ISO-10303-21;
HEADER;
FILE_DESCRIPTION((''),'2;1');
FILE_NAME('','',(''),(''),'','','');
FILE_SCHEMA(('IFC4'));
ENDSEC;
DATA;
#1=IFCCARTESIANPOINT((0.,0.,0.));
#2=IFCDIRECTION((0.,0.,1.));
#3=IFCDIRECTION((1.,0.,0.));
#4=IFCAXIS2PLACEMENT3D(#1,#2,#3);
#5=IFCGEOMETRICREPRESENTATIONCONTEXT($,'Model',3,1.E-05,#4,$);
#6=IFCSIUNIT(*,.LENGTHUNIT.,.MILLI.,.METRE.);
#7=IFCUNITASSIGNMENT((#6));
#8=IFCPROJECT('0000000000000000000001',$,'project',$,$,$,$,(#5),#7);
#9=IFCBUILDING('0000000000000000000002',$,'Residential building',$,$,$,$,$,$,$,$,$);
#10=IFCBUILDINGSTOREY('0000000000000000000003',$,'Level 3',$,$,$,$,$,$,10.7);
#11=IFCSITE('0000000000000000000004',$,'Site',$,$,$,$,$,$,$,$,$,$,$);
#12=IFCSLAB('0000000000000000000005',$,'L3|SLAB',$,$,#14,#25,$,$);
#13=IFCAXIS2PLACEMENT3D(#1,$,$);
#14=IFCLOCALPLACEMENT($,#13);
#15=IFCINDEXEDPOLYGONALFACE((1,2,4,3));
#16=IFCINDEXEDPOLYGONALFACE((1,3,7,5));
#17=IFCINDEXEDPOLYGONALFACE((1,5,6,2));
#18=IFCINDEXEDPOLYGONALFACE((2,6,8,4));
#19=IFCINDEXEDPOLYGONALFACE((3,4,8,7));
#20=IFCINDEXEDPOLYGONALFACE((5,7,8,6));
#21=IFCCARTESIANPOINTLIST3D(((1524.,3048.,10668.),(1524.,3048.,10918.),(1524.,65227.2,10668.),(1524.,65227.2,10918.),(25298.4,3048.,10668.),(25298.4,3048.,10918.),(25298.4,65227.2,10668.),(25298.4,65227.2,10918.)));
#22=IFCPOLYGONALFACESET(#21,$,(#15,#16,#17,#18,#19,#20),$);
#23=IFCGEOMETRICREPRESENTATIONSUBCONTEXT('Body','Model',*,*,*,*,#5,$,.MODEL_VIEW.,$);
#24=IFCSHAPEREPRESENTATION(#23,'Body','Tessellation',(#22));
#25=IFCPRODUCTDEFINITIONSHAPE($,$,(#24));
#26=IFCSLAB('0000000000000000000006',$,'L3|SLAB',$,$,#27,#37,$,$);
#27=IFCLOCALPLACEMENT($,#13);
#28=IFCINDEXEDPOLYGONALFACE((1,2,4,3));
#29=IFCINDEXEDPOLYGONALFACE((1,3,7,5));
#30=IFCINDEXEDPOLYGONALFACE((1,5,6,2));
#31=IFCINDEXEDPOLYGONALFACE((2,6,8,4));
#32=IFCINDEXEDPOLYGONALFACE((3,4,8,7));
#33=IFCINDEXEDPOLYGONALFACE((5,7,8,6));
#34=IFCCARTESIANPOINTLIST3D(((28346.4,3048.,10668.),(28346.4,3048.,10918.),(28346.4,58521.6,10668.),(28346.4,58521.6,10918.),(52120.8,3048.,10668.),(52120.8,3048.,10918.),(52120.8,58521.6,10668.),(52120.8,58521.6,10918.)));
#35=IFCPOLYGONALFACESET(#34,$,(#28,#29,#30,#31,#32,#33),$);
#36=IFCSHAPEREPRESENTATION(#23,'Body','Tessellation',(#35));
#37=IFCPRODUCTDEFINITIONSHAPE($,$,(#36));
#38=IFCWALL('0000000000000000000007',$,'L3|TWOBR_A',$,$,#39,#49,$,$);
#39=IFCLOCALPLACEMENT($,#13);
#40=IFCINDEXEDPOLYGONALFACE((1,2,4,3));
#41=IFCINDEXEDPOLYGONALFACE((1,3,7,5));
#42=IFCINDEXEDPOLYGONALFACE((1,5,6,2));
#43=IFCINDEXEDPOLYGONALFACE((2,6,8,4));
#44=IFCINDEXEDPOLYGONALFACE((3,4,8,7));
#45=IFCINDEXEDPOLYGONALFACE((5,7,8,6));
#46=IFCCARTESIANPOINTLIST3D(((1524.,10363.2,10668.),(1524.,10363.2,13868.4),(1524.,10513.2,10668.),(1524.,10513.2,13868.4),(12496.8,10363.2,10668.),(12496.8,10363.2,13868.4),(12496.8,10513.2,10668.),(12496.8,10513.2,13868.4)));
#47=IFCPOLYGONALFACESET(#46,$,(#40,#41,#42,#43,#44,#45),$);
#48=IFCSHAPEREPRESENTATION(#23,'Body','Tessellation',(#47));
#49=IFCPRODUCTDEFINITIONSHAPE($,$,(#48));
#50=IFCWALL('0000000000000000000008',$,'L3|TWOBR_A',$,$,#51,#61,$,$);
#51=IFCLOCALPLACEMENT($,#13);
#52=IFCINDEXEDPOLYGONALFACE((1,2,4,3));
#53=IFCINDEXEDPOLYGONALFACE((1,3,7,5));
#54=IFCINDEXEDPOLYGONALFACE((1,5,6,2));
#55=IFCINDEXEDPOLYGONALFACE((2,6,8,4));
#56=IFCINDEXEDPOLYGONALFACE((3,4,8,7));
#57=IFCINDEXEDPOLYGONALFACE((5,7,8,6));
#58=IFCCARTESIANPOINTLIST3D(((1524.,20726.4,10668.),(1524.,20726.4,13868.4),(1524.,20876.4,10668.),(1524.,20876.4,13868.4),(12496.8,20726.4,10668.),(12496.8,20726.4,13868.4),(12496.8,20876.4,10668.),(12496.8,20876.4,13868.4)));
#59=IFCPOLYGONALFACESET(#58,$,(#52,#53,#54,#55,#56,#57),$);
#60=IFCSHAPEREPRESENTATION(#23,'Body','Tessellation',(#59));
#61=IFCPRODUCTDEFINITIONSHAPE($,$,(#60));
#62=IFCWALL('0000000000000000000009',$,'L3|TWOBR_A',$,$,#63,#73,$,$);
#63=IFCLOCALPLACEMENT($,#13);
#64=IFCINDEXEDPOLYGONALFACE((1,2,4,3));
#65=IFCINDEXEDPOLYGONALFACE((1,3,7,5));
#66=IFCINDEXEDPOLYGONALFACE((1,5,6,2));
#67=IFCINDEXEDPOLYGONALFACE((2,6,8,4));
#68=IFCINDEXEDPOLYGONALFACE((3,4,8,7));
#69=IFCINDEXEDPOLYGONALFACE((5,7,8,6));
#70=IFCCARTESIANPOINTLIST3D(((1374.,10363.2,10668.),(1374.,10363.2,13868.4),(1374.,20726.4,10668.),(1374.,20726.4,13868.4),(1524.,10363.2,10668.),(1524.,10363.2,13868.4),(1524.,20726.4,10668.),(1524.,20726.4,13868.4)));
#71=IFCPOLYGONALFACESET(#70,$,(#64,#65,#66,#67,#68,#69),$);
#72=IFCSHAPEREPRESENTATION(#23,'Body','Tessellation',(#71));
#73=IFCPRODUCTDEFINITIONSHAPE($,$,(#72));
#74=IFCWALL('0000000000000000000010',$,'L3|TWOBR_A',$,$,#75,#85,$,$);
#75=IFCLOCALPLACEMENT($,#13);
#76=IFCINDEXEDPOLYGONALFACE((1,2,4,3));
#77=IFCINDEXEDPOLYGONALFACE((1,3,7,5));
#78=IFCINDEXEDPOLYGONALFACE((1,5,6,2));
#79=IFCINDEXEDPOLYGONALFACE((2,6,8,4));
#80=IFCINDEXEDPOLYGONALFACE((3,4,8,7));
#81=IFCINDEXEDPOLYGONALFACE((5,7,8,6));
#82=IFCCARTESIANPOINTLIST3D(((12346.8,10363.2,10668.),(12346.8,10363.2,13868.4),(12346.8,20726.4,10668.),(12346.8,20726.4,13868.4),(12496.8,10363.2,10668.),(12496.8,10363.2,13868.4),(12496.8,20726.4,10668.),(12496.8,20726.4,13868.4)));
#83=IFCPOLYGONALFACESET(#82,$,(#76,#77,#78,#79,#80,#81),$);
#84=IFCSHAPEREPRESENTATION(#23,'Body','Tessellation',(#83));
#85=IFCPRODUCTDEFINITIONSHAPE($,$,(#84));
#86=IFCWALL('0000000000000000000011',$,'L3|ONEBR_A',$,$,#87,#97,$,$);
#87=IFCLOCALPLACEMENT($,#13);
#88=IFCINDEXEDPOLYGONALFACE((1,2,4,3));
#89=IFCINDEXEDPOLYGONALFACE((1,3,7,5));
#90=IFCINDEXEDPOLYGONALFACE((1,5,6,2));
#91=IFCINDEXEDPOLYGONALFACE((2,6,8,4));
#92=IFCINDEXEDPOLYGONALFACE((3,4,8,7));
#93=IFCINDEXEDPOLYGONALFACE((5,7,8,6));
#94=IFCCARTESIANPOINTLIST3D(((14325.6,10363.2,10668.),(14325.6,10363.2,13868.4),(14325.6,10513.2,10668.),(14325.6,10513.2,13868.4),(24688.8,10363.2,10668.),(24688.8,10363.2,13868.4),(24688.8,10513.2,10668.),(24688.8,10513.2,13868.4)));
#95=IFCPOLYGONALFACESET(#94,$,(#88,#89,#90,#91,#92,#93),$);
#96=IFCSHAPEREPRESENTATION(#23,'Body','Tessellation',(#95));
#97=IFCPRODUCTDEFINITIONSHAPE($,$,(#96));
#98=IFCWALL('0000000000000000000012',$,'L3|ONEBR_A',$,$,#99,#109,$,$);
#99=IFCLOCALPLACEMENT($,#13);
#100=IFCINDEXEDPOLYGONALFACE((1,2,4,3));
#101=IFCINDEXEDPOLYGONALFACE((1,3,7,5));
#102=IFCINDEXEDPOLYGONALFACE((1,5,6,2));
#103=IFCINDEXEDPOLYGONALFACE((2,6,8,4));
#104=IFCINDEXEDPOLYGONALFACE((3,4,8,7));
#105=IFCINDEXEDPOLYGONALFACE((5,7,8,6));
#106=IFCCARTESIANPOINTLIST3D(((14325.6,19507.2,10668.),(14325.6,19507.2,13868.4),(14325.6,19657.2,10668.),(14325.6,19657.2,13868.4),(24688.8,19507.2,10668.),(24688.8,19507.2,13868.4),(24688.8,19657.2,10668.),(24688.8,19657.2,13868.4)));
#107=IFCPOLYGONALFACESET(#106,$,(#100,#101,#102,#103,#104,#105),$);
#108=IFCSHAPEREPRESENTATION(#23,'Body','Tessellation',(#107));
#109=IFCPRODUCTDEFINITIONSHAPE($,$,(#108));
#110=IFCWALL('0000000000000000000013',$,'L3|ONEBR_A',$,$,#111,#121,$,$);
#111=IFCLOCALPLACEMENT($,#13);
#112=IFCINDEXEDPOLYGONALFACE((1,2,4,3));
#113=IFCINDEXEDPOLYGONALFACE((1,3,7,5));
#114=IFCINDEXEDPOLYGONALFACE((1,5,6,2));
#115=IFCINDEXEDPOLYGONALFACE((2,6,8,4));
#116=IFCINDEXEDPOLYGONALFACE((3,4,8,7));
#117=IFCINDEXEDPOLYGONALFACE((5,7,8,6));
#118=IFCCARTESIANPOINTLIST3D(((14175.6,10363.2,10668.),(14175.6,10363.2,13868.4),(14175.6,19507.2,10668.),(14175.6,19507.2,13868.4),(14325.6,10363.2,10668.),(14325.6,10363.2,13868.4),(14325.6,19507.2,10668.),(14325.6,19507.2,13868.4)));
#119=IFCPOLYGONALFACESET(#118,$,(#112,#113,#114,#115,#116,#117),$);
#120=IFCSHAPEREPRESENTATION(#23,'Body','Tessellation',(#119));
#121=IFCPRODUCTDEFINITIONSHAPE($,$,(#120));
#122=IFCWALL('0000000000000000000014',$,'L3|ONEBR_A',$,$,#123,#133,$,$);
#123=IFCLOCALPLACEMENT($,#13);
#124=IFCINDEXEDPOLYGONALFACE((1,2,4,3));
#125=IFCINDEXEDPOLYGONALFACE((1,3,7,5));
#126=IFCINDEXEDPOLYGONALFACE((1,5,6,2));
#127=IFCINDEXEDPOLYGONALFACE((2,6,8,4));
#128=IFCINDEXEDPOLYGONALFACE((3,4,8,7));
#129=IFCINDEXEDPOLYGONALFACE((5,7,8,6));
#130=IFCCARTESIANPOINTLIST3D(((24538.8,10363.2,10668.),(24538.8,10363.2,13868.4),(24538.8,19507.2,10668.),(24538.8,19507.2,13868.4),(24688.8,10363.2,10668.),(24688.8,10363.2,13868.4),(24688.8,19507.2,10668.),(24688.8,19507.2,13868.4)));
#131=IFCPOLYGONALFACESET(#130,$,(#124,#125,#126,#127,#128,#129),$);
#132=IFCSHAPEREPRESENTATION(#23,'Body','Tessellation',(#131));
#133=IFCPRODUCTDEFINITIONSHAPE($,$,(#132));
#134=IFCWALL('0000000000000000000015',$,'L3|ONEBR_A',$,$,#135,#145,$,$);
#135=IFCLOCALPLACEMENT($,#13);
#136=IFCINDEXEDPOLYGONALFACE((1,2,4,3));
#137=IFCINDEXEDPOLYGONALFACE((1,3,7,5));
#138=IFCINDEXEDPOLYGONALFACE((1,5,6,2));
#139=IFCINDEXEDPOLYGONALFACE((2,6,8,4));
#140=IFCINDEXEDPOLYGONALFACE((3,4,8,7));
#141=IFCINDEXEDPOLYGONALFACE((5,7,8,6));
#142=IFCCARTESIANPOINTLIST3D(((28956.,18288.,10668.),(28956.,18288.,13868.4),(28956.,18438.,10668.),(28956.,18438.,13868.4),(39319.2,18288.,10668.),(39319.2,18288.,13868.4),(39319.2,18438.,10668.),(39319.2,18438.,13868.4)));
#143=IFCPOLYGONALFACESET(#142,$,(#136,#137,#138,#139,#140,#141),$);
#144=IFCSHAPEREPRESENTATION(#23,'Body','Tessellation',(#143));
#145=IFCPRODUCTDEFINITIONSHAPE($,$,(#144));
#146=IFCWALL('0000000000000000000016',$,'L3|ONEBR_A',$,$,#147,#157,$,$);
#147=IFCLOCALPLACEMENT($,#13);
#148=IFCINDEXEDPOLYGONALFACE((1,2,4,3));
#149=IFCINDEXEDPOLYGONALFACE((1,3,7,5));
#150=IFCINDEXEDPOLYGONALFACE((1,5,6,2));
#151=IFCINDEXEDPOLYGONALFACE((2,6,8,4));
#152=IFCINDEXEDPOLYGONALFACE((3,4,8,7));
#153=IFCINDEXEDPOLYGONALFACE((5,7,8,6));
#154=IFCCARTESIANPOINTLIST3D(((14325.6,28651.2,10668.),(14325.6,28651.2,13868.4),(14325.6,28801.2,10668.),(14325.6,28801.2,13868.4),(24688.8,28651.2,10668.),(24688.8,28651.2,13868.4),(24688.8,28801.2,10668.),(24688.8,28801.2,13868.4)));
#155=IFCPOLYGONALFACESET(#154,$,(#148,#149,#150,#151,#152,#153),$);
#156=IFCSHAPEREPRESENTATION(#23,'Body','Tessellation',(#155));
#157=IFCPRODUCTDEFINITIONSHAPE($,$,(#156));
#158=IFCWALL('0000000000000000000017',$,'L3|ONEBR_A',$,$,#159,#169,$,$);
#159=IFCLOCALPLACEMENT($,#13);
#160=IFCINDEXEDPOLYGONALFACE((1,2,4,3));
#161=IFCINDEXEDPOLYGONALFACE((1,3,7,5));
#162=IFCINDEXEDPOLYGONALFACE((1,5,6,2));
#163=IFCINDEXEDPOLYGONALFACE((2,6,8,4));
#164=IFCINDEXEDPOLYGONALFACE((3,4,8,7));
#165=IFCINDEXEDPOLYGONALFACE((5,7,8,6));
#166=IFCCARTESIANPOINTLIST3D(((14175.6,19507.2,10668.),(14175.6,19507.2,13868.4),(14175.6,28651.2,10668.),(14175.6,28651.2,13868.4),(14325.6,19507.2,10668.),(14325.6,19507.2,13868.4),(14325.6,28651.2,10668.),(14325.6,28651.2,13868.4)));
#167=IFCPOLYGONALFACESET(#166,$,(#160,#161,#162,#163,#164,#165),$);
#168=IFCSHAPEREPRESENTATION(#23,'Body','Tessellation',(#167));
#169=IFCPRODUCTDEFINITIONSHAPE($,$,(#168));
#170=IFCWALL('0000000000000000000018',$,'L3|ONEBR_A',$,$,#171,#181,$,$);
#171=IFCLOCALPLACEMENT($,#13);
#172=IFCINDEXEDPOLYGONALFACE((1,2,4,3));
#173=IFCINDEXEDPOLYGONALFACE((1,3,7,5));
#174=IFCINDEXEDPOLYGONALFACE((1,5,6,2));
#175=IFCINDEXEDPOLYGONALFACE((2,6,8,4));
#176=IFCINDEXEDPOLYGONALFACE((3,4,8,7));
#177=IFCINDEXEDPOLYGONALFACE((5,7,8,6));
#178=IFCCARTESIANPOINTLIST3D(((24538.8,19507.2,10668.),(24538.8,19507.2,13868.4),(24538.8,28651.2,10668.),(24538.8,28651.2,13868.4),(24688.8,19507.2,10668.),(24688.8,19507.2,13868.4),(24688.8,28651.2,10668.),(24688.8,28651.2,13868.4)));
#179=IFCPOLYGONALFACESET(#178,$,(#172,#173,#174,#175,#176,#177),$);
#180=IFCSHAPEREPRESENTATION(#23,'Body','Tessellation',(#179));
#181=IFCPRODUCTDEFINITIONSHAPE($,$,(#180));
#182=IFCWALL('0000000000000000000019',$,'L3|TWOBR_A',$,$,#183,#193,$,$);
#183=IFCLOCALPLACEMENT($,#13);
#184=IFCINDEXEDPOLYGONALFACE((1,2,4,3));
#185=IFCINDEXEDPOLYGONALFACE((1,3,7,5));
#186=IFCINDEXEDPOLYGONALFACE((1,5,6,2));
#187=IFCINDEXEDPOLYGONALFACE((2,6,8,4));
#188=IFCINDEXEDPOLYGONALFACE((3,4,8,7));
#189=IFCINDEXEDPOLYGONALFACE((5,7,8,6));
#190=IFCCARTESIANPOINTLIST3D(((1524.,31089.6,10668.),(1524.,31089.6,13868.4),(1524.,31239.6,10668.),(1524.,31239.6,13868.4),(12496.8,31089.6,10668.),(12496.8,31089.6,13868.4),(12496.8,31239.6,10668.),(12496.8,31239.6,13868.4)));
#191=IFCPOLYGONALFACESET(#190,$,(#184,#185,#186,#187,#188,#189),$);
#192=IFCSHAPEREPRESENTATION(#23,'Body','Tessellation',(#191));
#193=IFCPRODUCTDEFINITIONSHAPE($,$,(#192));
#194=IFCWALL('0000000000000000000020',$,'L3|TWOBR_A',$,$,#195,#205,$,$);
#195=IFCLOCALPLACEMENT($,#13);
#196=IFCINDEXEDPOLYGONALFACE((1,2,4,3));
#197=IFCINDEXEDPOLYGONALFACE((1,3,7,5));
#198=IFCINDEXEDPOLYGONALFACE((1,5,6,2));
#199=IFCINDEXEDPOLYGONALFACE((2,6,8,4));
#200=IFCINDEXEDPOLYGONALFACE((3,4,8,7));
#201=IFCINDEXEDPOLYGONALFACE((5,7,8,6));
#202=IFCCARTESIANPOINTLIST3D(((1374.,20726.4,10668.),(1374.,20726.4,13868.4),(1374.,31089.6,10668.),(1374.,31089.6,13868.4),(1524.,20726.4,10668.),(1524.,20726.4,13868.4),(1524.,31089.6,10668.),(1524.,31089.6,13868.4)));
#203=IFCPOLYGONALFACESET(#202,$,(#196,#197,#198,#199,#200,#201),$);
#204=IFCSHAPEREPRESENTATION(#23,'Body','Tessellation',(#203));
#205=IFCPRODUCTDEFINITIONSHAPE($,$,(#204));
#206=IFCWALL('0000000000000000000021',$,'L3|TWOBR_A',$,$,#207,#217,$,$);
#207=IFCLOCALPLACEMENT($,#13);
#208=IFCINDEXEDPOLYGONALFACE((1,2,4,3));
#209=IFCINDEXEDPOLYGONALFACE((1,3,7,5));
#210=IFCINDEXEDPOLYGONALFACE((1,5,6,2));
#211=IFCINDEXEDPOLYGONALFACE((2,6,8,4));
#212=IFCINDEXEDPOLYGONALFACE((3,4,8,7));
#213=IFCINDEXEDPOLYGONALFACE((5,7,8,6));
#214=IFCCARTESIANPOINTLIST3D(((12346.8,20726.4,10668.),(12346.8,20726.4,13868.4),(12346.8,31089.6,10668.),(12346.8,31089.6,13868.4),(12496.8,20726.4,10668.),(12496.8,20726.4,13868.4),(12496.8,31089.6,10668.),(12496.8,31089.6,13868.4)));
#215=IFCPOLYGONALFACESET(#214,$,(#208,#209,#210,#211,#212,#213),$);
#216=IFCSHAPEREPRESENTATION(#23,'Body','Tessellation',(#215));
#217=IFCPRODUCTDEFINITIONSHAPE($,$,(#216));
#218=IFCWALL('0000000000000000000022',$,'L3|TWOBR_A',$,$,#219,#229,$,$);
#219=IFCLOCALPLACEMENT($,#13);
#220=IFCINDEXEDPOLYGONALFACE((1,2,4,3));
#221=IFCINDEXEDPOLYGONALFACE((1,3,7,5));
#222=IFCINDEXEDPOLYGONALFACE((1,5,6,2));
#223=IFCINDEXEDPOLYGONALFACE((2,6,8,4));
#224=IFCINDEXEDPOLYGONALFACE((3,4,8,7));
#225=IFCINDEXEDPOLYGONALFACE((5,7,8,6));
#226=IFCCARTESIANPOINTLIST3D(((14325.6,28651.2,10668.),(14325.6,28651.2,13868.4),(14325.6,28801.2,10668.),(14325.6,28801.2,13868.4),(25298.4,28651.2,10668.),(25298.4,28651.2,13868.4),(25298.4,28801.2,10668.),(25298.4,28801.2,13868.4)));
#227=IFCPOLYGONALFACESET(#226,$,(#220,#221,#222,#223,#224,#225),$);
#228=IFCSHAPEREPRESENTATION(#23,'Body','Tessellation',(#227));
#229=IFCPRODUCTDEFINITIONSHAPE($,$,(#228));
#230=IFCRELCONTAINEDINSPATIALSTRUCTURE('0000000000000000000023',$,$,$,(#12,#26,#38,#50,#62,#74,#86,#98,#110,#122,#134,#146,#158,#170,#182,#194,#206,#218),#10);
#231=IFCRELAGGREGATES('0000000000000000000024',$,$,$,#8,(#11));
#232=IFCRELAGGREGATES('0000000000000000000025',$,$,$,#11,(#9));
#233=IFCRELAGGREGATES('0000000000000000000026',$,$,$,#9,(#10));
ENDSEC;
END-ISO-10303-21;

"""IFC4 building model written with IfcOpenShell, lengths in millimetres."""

from ifc_helpers import new_model, si_unit, frame, origin_with_axes, place, context, subcontext, project, spatial, indexed_curve, outline, extrude, element, save


model = new_model("IFC4")

# Units and contexts
model_context = context("Model", 3, precision=1e-05, world=origin_with_axes())
body_context = subcontext(model_context, "Body", "Model", "MODEL_VIEW")
ifc_project = project(units=[si_unit("LENGTHUNIT", "METRE", prefix="MILLI")], contexts=[model_context])

# Site, building, storey
site = spatial("IfcSite", under=ifc_project, Name="Site")
building = spatial("IfcBuilding", under=site, Name="Residential building")
storey = spatial("IfcBuildingStorey", under=building, Name="Level 3", Elevation=10.7)

# Slabs
slab_1_placement = place(None, frame((1524.0, 3048.0, 10668.0), z_axis=(0.0, 0.0, 1.0), x_axis=(1.0, 0.0, 0.0)))
element("IfcSlab", 1, at=slab_1_placement, inside=storey, Name="L3|SLAB", context=body_context, shape_type="SweptSolid", body=[
    extrude(outline(indexed_curve([(0.0, 0.0), (23774.4, 0.0), (23774.4, 62179.2), (0.0, 62179.2), (0.0, 0.0)])), None, (0.0, 0.0, 1.0), 250.0),
])
slab_2_placement = place(None, frame((28346.4, 3048.0, 10668.0), z_axis=(0.0, 0.0, 1.0), x_axis=(1.0, 0.0, 0.0)))
element("IfcSlab", 2, at=slab_2_placement, inside=storey, Name="L3|SLAB", context=body_context, shape_type="SweptSolid", body=[
    extrude(outline(indexed_curve([(0.0, 0.0), (23774.4, 0.0), (23774.4, 55473.6), (0.0, 55473.6), (0.0, 0.0)])), None, (0.0, 0.0, 1.0), 250.0),
])

# Walls
for number, where, z_axis, x_axis, name in (
    (3, (1524.0, 10363.2, 10668.0), (0.0, 0.0, 1.0), (1.0, 0.0, 0.0), "L3|TWOBR_A"),
    (4, (1524.0, 20726.4, 10668.0), (0.0, 0.0, 1.0), (1.0, 0.0, 0.0), "L3|TWOBR_A"),
):
    element("IfcWall", number, at=place(None, frame(where, z_axis=z_axis, x_axis=x_axis)), inside=storey, Name=name, context=body_context, shape_type="SweptSolid", body=[
        extrude(outline(indexed_curve([(0.0, 0.0), (0.0, 150.0), (10972.8, 150.0), (10972.8, 0.0), (0.0, 0.0)], self_intersect=False)), origin_with_axes(), (0.0, 0.0, 1.0), 3200.4),
    ])
for number, where, z_axis, x_axis, name in (
    (5, (1524.0, 10363.2, 10668.0), (0.0, 0.0, 1.0), (0.0, 1.0, 0.0), "L3|TWOBR_A"),
    (6, (12496.8, 10363.2, 10668.0), (0.0, 0.0, 1.0), (0.0, 1.0, 0.0), "L3|TWOBR_A"),
    (7, (14325.6, 10363.2, 10668.0), (0.0, 0.0, 1.0), (1.0, 0.0, 0.0), "L3|ONEBR_A"),
    (8, (14325.6, 19507.2, 10668.0), (0.0, 0.0, 1.0), (1.0, 0.0, 0.0), "L3|ONEBR_A"),
):
    element("IfcWall", number, at=place(None, frame(where, z_axis=z_axis, x_axis=x_axis)), inside=storey, Name=name, context=body_context, shape_type="SweptSolid", body=[
        extrude(outline(indexed_curve([(0.0, 0.0), (0.0, 150.0), (10363.2, 150.0), (10363.2, 0.0), (0.0, 0.0)], self_intersect=False)), origin_with_axes(), (0.0, 0.0, 1.0), 3200.4),
    ])
for number, where, z_axis, x_axis, name in (
    (9, (14325.6, 10363.2, 10668.0), (0.0, 0.0, 1.0), (0.0, 1.0, 0.0), "L3|ONEBR_A"),
    (10, (24688.8, 10363.2, 10668.0), (0.0, 0.0, 1.0), (0.0, 1.0, 0.0), "L3|ONEBR_A"),
):
    element("IfcWall", number, at=place(None, frame(where, z_axis=z_axis, x_axis=x_axis)), inside=storey, Name=name, context=body_context, shape_type="SweptSolid", body=[
        extrude(outline(indexed_curve([(0.0, 0.0), (0.0, 150.0), (9144.0, 150.0), (9144.0, 0.0), (0.0, 0.0)], self_intersect=False)), origin_with_axes(), (0.0, 0.0, 1.0), 3200.4),
    ])
for number, where, z_axis, x_axis, name in (
    (11, (28956.0, 18288.0, 10668.0), (0.0, 0.0, 1.0), (1.0, 0.0, 0.0), "L3|ONEBR_A"),
    (12, (14325.6, 28651.2, 10668.0), (0.0, 0.0, 1.0), (1.0, 0.0, 0.0), "L3|ONEBR_A"),
):
    element("IfcWall", number, at=place(None, frame(where, z_axis=z_axis, x_axis=x_axis)), inside=storey, Name=name, context=body_context, shape_type="SweptSolid", body=[
        extrude(outline(indexed_curve([(0.0, 0.0), (0.0, 150.0), (10363.2, 150.0), (10363.2, 0.0), (0.0, 0.0)], self_intersect=False)), origin_with_axes(), (0.0, 0.0, 1.0), 3200.4),
    ])
for number, where, z_axis, x_axis, name in (
    (13, (14325.6, 19507.2, 10668.0), (0.0, 0.0, 1.0), (0.0, 1.0, 0.0), "L3|ONEBR_A"),
    (14, (24688.8, 19507.2, 10668.0), (0.0, 0.0, 1.0), (0.0, 1.0, 0.0), "L3|ONEBR_A"),
):
    element("IfcWall", number, at=place(None, frame(where, z_axis=z_axis, x_axis=x_axis)), inside=storey, Name=name, context=body_context, shape_type="SweptSolid", body=[
        extrude(outline(indexed_curve([(0.0, 0.0), (0.0, 150.0), (9144.0, 150.0), (9144.0, 0.0), (0.0, 0.0)], self_intersect=False)), origin_with_axes(), (0.0, 0.0, 1.0), 3200.4),
    ])
for number, where, z_axis, x_axis, name in (
    (15, (1524.0, 31089.6, 10668.0), (0.0, 0.0, 1.0), (1.0, 0.0, 0.0), "L3|TWOBR_A"),
):
    element("IfcWall", number, at=place(None, frame(where, z_axis=z_axis, x_axis=x_axis)), inside=storey, Name=name, context=body_context, shape_type="SweptSolid", body=[
        extrude(outline(indexed_curve([(0.0, 0.0), (0.0, 150.0), (10972.8, 150.0), (10972.8, 0.0), (0.0, 0.0)], self_intersect=False)), origin_with_axes(), (0.0, 0.0, 1.0), 3200.4),
    ])
for number, where, z_axis, x_axis, name in (
    (16, (1524.0, 20726.4, 10668.0), (0.0, 0.0, 1.0), (0.0, 1.0, 0.0), "L3|TWOBR_A"),
    (17, (12496.8, 20726.4, 10668.0), (0.0, 0.0, 1.0), (0.0, 1.0, 0.0), "L3|TWOBR_A"),
):
    element("IfcWall", number, at=place(None, frame(where, z_axis=z_axis, x_axis=x_axis)), inside=storey, Name=name, context=body_context, shape_type="SweptSolid", body=[
        extrude(outline(indexed_curve([(0.0, 0.0), (0.0, 150.0), (10363.2, 150.0), (10363.2, 0.0), (0.0, 0.0)], self_intersect=False)), origin_with_axes(), (0.0, 0.0, 1.0), 3200.4),
    ])
for number, where, z_axis, x_axis, name in (
    (18, (14325.6, 28651.2, 10668.0), (0.0, 0.0, 1.0), (1.0, 0.0, 0.0), "L3|TWOBR_A"),
):
    element("IfcWall", number, at=place(None, frame(where, z_axis=z_axis, x_axis=x_axis)), inside=storey, Name=name, context=body_context, shape_type="SweptSolid", body=[
        extrude(outline(indexed_curve([(0.0, 0.0), (0.0, 150.0), (10972.8, 150.0), (10972.8, 0.0), (0.0, 0.0)], self_intersect=False)), origin_with_axes(), (0.0, 0.0, 1.0), 3200.4),
    ])

save(model, "model.ifc")
